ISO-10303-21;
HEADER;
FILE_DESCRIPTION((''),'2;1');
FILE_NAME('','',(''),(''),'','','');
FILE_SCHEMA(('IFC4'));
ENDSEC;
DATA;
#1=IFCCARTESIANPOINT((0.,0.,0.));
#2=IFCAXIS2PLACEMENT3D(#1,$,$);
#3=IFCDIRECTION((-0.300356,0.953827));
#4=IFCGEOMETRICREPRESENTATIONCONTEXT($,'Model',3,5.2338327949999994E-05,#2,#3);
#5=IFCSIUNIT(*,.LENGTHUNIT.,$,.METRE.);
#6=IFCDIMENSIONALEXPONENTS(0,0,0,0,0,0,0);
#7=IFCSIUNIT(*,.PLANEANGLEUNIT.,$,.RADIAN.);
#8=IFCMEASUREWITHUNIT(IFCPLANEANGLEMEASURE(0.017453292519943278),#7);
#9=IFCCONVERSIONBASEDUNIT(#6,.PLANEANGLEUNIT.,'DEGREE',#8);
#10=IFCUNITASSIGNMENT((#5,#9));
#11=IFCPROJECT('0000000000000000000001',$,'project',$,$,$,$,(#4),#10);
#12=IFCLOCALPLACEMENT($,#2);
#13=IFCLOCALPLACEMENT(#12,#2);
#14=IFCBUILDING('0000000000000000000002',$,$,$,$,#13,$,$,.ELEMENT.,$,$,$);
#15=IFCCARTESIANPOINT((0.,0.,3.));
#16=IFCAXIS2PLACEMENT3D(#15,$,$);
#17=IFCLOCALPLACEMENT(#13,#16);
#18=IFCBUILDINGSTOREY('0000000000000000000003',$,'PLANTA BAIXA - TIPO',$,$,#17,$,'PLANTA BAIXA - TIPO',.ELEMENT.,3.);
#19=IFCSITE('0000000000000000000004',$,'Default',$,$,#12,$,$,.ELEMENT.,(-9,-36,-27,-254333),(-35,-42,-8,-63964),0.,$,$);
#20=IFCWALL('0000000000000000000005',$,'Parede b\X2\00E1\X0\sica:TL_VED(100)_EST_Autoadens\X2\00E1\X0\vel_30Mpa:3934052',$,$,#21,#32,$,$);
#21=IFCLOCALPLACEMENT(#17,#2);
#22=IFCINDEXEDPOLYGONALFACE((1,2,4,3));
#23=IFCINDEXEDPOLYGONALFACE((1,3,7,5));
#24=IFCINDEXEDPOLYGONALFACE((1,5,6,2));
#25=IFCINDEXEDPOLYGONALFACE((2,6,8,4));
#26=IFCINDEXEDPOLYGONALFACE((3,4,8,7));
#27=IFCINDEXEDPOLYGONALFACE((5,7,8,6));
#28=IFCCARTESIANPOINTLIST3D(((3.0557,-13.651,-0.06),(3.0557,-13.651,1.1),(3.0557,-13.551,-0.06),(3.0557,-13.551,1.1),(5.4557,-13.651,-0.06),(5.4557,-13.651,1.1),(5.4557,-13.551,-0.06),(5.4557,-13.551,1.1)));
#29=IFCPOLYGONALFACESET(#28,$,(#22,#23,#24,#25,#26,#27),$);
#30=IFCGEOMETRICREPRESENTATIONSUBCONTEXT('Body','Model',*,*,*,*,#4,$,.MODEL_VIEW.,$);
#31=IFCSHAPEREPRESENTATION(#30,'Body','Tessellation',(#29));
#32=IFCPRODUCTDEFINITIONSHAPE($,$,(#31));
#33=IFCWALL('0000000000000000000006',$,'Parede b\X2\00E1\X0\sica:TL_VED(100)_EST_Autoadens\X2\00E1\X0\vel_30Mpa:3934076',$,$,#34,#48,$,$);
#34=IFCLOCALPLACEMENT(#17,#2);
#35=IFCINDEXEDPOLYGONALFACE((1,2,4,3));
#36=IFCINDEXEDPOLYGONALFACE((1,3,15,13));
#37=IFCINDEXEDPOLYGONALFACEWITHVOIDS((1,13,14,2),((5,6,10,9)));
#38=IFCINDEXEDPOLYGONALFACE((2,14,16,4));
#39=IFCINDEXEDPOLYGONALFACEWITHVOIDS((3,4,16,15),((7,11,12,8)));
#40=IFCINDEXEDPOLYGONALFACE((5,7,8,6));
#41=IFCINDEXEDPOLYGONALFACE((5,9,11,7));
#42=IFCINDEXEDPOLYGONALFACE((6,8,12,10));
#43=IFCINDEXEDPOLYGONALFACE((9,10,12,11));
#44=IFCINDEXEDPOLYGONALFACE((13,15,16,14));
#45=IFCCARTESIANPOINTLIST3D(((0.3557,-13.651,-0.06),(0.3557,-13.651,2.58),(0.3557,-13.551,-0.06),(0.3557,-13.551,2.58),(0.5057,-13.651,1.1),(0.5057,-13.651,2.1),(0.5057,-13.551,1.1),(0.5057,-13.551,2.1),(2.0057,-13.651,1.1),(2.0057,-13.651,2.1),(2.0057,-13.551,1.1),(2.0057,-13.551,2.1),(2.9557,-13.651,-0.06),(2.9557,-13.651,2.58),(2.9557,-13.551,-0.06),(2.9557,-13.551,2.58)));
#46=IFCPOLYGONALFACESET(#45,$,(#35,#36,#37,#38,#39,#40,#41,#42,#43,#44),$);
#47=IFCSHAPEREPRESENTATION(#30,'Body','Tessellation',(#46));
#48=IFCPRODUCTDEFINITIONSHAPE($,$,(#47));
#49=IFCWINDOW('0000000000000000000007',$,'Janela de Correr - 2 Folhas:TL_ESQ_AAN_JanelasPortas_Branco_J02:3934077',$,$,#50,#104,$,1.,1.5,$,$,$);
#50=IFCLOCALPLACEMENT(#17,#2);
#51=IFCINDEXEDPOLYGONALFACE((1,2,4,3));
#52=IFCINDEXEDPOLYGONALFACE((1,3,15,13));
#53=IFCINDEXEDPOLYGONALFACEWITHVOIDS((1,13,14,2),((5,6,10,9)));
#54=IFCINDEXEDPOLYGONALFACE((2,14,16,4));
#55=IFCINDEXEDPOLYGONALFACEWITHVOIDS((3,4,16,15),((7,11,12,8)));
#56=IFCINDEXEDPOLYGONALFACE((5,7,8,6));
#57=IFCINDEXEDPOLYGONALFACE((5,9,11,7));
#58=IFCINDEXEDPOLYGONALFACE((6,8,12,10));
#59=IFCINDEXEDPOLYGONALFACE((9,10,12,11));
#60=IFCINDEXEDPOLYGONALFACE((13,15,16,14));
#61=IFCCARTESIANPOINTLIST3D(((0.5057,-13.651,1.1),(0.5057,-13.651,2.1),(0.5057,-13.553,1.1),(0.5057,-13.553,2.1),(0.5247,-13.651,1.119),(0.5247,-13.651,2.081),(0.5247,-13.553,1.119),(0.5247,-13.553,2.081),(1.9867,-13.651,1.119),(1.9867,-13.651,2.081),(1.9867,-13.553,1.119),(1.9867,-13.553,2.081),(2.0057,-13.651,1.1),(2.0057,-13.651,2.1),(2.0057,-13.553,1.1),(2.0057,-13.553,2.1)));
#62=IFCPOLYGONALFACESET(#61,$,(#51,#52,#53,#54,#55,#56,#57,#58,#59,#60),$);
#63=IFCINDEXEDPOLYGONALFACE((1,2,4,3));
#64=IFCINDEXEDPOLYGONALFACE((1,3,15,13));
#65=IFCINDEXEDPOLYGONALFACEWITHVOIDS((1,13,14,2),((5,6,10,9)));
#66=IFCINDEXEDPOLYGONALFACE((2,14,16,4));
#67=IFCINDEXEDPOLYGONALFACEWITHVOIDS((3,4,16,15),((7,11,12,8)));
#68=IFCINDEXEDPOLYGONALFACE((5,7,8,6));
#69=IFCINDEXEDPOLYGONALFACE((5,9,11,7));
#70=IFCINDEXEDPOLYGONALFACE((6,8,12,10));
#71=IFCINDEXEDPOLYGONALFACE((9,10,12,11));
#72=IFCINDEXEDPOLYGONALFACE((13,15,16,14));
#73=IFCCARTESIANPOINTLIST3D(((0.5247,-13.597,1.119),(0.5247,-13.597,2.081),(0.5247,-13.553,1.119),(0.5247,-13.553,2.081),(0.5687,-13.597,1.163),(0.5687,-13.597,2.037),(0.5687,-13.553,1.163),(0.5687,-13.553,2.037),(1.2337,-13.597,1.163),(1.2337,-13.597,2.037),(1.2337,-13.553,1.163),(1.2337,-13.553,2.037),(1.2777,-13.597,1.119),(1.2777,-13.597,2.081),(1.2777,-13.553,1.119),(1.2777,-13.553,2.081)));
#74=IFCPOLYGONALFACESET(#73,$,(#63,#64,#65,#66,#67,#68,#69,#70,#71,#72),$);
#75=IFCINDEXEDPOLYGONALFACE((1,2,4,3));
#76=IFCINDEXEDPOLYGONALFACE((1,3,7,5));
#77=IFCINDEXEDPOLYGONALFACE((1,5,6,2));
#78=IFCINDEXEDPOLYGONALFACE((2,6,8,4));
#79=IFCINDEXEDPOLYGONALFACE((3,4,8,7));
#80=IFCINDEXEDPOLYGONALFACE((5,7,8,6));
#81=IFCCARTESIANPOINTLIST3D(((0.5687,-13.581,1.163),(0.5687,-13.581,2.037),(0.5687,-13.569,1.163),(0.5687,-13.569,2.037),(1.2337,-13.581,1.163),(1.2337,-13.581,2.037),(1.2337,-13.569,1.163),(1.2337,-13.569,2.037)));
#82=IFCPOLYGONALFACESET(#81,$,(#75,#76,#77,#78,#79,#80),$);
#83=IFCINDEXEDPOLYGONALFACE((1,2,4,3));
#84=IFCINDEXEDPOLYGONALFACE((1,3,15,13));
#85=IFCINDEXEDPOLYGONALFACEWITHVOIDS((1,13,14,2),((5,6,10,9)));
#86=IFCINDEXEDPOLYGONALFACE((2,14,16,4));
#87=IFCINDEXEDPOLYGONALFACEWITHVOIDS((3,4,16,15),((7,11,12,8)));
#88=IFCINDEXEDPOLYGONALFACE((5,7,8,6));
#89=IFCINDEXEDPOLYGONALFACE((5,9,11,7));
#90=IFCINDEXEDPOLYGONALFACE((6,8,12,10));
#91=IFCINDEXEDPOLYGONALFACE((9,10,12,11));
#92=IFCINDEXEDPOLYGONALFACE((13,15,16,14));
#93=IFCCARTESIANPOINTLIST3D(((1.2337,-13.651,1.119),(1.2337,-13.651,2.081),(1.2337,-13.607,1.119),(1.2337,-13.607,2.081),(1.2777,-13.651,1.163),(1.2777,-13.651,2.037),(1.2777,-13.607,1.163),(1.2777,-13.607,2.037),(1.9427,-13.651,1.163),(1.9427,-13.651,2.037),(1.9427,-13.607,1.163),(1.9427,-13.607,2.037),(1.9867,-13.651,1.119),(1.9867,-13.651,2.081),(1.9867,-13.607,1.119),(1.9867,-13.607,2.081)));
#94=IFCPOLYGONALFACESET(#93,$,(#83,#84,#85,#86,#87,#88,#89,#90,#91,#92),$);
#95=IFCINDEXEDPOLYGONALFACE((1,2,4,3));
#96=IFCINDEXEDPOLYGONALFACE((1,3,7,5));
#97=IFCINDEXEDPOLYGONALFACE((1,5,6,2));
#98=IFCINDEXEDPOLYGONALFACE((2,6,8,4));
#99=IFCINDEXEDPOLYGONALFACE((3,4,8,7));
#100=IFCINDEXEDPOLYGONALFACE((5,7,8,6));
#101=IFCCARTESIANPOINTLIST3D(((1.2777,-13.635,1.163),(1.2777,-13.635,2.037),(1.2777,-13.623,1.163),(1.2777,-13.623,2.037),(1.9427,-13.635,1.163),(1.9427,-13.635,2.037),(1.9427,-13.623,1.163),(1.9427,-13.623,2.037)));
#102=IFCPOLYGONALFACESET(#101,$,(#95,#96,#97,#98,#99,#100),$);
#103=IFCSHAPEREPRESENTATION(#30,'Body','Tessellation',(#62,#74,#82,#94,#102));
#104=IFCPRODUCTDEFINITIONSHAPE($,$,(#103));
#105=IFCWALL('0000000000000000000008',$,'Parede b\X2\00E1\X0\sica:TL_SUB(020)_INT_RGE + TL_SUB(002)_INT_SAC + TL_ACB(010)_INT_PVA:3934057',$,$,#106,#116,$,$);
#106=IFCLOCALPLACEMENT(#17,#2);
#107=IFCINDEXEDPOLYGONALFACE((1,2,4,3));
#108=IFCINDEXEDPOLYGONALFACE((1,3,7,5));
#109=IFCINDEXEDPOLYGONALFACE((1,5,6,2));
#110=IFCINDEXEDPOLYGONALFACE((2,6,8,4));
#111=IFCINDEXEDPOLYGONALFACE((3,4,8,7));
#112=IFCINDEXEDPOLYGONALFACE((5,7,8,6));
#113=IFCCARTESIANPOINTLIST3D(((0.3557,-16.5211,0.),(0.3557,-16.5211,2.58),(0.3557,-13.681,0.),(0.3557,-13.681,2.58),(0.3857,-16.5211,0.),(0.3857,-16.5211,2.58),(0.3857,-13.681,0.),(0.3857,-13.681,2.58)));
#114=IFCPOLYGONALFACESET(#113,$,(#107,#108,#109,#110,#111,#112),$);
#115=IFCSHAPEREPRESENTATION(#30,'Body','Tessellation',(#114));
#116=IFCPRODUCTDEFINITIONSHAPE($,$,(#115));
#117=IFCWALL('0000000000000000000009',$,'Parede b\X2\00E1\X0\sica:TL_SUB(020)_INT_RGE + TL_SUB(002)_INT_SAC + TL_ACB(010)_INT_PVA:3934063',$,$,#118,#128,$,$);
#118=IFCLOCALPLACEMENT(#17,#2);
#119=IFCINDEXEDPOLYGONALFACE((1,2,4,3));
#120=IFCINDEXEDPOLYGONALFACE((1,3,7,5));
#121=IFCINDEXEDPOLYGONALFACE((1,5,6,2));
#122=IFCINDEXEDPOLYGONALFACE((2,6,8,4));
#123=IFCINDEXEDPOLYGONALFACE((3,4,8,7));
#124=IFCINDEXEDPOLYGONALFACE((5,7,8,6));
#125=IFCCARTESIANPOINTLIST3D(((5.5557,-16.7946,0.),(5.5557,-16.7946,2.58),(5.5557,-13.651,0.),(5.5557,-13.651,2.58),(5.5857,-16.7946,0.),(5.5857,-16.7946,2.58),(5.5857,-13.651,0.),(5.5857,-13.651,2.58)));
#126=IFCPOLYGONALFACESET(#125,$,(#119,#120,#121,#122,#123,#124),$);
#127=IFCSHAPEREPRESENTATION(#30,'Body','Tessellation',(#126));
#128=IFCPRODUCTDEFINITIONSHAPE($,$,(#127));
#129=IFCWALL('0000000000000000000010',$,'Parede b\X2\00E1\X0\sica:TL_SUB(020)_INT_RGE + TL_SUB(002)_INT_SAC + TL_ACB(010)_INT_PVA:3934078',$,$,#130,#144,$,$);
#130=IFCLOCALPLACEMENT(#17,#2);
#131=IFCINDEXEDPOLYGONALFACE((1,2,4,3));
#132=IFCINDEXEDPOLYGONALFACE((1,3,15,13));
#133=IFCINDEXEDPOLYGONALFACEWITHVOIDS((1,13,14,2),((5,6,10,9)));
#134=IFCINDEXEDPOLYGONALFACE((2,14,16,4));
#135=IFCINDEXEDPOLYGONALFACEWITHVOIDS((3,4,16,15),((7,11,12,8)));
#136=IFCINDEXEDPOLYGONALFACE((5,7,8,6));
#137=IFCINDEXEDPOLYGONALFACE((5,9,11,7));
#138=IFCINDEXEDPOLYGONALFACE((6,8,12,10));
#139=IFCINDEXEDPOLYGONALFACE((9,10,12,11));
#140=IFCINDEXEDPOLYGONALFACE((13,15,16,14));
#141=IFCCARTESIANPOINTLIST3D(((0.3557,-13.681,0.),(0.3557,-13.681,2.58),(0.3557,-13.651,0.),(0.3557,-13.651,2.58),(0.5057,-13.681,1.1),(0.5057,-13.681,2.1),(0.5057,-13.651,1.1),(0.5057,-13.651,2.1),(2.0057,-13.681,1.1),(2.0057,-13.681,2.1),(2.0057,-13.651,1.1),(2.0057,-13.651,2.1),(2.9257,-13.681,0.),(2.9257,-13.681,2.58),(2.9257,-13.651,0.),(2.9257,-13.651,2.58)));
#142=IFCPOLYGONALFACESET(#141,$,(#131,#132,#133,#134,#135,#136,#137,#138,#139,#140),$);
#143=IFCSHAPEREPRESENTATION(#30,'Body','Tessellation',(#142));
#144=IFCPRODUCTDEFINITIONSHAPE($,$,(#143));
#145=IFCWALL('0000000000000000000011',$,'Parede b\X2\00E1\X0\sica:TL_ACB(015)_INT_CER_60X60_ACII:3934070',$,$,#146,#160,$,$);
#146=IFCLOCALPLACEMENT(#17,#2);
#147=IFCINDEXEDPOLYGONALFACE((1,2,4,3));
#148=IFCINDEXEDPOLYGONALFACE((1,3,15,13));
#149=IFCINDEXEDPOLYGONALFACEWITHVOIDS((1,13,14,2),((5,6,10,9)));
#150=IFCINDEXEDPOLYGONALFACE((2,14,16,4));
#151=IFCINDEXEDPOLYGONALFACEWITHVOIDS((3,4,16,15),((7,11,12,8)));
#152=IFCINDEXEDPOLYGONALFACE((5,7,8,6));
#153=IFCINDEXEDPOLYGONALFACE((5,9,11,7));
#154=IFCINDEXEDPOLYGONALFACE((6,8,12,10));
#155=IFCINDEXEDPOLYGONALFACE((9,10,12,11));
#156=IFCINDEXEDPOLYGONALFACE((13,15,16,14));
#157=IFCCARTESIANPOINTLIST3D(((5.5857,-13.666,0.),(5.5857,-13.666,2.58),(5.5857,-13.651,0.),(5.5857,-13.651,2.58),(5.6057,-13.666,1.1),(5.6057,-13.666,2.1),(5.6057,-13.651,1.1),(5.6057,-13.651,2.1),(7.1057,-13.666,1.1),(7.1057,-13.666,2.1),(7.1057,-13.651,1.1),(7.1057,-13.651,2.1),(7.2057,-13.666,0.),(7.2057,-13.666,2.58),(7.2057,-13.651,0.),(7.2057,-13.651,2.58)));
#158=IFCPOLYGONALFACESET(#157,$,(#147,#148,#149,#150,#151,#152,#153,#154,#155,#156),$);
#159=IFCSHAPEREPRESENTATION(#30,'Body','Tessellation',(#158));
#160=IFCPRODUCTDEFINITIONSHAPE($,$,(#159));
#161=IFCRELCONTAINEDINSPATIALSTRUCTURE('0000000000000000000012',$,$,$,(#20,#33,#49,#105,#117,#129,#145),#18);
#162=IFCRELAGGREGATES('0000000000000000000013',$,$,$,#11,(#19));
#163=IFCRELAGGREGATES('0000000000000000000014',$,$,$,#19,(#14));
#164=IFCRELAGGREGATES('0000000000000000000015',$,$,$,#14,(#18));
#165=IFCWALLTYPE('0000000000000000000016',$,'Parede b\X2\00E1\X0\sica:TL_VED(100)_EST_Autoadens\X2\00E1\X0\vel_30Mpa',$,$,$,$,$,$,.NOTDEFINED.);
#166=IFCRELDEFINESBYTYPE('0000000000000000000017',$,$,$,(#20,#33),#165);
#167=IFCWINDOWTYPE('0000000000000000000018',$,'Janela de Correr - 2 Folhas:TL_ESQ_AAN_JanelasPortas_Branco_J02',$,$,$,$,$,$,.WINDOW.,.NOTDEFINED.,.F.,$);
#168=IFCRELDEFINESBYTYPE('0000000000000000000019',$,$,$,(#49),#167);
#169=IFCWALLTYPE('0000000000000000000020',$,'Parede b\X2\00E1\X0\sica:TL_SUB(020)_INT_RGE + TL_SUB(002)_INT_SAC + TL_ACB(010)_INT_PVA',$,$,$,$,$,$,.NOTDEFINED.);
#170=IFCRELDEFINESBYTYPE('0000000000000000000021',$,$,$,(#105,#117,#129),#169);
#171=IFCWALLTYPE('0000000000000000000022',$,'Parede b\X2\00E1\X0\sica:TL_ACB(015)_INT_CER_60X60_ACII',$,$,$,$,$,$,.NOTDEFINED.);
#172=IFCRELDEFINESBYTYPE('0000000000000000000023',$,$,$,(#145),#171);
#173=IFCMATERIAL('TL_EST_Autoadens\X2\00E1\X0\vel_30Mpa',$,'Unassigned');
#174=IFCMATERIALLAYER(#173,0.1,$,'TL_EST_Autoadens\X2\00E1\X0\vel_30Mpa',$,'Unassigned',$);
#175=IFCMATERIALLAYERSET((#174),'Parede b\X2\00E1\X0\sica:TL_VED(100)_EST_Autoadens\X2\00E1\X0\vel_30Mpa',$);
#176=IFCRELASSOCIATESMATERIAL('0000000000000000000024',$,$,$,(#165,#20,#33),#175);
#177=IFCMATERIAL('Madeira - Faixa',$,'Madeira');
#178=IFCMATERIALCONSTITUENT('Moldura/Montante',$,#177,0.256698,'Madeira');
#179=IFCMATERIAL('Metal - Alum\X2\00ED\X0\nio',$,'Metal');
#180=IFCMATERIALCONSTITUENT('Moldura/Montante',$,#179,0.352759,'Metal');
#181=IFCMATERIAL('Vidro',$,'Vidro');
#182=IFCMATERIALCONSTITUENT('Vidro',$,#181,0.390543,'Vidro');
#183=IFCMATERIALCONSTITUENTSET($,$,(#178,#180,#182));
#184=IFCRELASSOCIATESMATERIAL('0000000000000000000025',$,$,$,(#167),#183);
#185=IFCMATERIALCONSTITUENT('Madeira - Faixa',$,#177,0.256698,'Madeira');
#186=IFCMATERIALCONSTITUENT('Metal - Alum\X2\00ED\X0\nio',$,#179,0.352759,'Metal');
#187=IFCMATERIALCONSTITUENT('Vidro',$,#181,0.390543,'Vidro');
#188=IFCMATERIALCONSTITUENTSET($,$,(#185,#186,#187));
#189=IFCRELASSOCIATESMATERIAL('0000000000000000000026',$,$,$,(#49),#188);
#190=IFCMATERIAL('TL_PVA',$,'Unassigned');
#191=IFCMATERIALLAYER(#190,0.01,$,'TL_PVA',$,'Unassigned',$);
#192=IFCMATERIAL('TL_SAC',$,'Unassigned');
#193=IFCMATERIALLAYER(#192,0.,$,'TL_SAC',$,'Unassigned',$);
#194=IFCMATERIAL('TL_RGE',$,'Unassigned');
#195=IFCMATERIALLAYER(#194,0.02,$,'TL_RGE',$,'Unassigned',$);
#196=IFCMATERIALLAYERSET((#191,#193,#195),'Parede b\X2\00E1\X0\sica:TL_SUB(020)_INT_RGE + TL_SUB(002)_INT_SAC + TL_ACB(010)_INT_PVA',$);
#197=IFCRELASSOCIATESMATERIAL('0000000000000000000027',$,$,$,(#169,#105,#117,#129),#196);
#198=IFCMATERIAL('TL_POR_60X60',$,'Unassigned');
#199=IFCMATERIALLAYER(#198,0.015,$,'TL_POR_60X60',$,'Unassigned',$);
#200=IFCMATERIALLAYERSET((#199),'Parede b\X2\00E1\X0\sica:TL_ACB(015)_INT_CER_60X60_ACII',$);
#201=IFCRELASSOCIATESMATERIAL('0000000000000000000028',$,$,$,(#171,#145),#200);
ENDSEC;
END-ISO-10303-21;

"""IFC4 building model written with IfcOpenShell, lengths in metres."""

from ifc_helpers import new_model, entity, si_unit, converted_unit, direction, frame, frame_2d, origin, origin_2d_with_axis, place, context, subcontext, project, spatial, polyline, rectangle, outline, extrude, source, transform, mapped, material, layer, layer_set, layer_usage, constituent, constituent_set, type_object, type_shapes, element, fill, save


model = new_model("IFC4")

# Units and contexts
model_context = context("Model", 3, precision=5.2338327949999994e-05, world=origin(), true_north=direction((-0.300356, 0.953827)))
body_context = subcontext(model_context, "Body", "Model", "MODEL_VIEW")
ifc_project = project(units=[si_unit("LENGTHUNIT", "METRE"), converted_unit("PLANEANGLEUNIT", "DEGREE", entity("IfcPlaneAngleMeasure", 0.017453292519943278), si_unit("PLANEANGLEUNIT", "RADIAN"), dimensions=[0, 0, 0, 0, 0, 0, 0])], contexts=[model_context])

# Site, building, storey
site_placement = place(None, origin())
site = spatial("IfcSite", under=ifc_project, at=site_placement, Name="Default", CompositionType="ELEMENT", RefLatitude=(-9, -36, -27, -254333), RefLongitude=(-35, -42, -8, -63964), RefElevation=0.0)
building_placement = place(site_placement, origin())
building = spatial("IfcBuilding", under=site, at=building_placement, CompositionType="ELEMENT")
storey_placement = place(building_placement, frame((0.0, 0.0, 3.0)))
storey = spatial("IfcBuildingStorey", under=building, at=storey_placement, Name="PLANTA BAIXA - TIPO", LongName="PLANTA BAIXA - TIPO", CompositionType="ELEMENT", Elevation=3.0)

# Wall
ifc_material_1 = material(Name="TL_EST_Autoadensável_30Mpa", Category="Unassigned")
ifc_layer_1 = layer(ifc_material_1, 0.1, Name="TL_EST_Autoadensável_30Mpa", Category="Unassigned")
ifc_layer_set_1 = layer_set([ifc_layer_1], Name="Parede básica:TL_VED(100)_EST_Autoadensável_30Mpa")
ifc_layer_usage_1 = layer_usage(ifc_layer_set_1, "AXIS2", "NEGATIVE", 0.05)
wall_type_1 = type_object("IfcWallType", Name="Parede básica:TL_VED(100)_EST_Autoadensável_30Mpa", PredefinedType="NOTDEFINED", material=ifc_layer_set_1)
wall_1_placement = place(storey_placement, frame((3.0557, -13.601, -0.06)))
element("IfcWall", 1, at=wall_1_placement, inside=storey, type_object=wall_type_1, material=ifc_layer_usage_1, Name="Parede básica:TL_VED(100)_EST_Autoadensável_30Mpa:3934052", context=body_context, shape_type="SweptSolid", body=[
    extrude(rectangle(XDim=2.4, YDim=0.1, at=frame_2d((1.2, 0.0), x_axis=(-1.0, 0.0))), origin(), (0.0, 0.0, 1.0), 1.16),
])

# Wall, opening, window
ifc_layer_usage_2 = layer_usage(ifc_layer_set_1, "AXIS2", "NEGATIVE", 0.05)
wall_2_placement = place(storey_placement, frame((0.3557, -13.601, -0.06)))
wall_2 = element("IfcWall", 2, at=wall_2_placement, inside=storey, type_object=wall_type_1, material=ifc_layer_usage_2, Name="Parede básica:TL_VED(100)_EST_Autoadensável_30Mpa:3934076", context=body_context, shape_type="SweptSolid", body=[
    extrude(rectangle(XDim=2.6, YDim=0.1, at=frame_2d((1.3, 0.0), x_axis=(-1.0, 0.0))), origin(), (0.0, 0.0, 1.0), 2.64),
])
opening_1_placement = place(wall_2_placement, frame((0.15, -0.05, 1.16)))
opening_1 = element("IfcOpeningElement", 3, at=opening_1_placement, cuts=wall_2, PredefinedType="OPENING", context=body_context, shape_type="SweptSolid", body=[
    extrude(rectangle(XDim=1.0, YDim=1.5, at=frame_2d((0.5, 0.75), x_axis=(-1.0, 0.0))), frame((0.0, 0.0, 0.0), z_axis=(0.0, 1.0, 0.0), x_axis=(0.0, 0.0, 1.0)), (0.0, 0.0, 1.0), 0.1),
])
ifc_material_2 = material(Name="Madeira - Faixa", Category="Madeira")
ifc_constituent_1 = constituent(ifc_material_2, Name="Madeira - Faixa", Category="Madeira", fraction=0.256698)
ifc_material_3 = material(Name="Metal - Alumínio", Category="Metal")
ifc_constituent_2 = constituent(ifc_material_3, Name="Metal - Alumínio", Category="Metal", fraction=0.352759)
ifc_material_4 = material(Name="Vidro", Category="Vidro")
ifc_constituent_3 = constituent(ifc_material_4, Name="Vidro", Category="Vidro", fraction=0.390543)
ifc_constituent_set_1 = constituent_set(constituents=[ifc_constituent_1, ifc_constituent_2, ifc_constituent_3])
ifc_constituent_4 = constituent(ifc_material_2, Name="Moldura/Montante", Category="Madeira", fraction=0.256698)
ifc_constituent_5 = constituent(ifc_material_3, Name="Moldura/Montante", Category="Metal", fraction=0.352759)
ifc_constituent_6 = constituent(ifc_material_4, Name="Vidro", Category="Vidro", fraction=0.390543)
ifc_constituent_set_2 = constituent_set(constituents=[ifc_constituent_4, ifc_constituent_5, ifc_constituent_6])
window_type = type_object("IfcWindowType", Name="Janela de Correr - 2 Folhas:TL_ESQ_AAN_JanelasPortas_Branco_J02", ParameterTakesPrecedence=False, PartitioningType="NOTDEFINED", PredefinedType="WINDOW", material=ifc_constituent_set_2)
shared_shape_1 = source(origin(), body_context, "Body", "SweptSolid", [
    extrude(outline(polyline([(-0.75, -0.5), (0.75, -0.5), (0.75, 0.5), (-0.75, 0.5), (-0.75, -0.5)]), holes=[polyline([(-0.731, -0.481), (-0.731, 0.481), (0.731, 0.481), (0.731, -0.481), (-0.731, -0.481)])]), frame((0.75, 0.124, 0.5), z_axis=(0.0, -1.0, 0.0), x_axis=(-1.0, 0.0, 0.0)), (0.0, 0.0, 1.0), 0.098),
    extrude(outline(polyline([(-0.3765, -0.481), (0.3765, -0.481), (0.3765, 0.481), (-0.3765, 0.481), (-0.3765, -0.481)]), holes=[polyline([(-0.3325, -0.437), (-0.3325, 0.437), (0.3325, 0.437), (0.3325, -0.437), (-0.3325, -0.437)])]), frame((0.3955, 0.124, 0.5), z_axis=(0.0, -1.0, 0.0), x_axis=(-1.0, 0.0, 0.0)), (0.0, 0.0, 1.0), 0.044),
    extrude(rectangle(XDim=0.665, YDim=0.012, at=origin_2d_with_axis()), frame((0.3955, 0.102, 0.063), z_axis=(0.0, 0.0, 1.0), x_axis=(-1.0, 0.0, 0.0)), (0.0, 0.0, 1.0), 0.874),
    extrude(outline(polyline([(-0.481, -0.3765), (0.481, -0.3765), (0.481, 0.3765), (-0.481, 0.3765), (-0.481, -0.3765)]), holes=[polyline([(-0.437, -0.3325), (-0.437, 0.3325), (0.437, 0.3325), (0.437, -0.3325), (-0.437, -0.3325)])]), frame((1.1045, 0.07, 0.5), z_axis=(0.0, -1.0, 0.0), x_axis=(0.0, 0.0, -1.0)), (0.0, 0.0, 1.0), 0.044),
    extrude(rectangle(XDim=0.665, YDim=0.012, at=origin_2d_with_axis()), frame((1.1045, 0.048, 0.063), z_axis=(0.0, 0.0, 1.0), x_axis=(-1.0, 0.0, 0.0)), (0.0, 0.0, 1.0), 0.874),
])
type_shapes(window_type, [shared_shape_1])
window_placement = place(opening_1_placement, frame((0.0, -0.026, 0.0)))
window = element("IfcWindow", 4, at=window_placement, inside=storey, type_object=window_type, material=ifc_constituent_set_1, Name="Janela de Correr - 2 Folhas:TL_ESQ_AAN_JanelasPortas_Branco_J02:3934077", OverallHeight=1.0, OverallWidth=1.5, context=body_context, shape_type="MappedRepresentation", body=[
    mapped(shared_shape_1, transform((0.0, 0.0, 0.0), scale=1.0)),
])
fill(opening_1, window)

# Walls
ifc_material_5 = material(Name="TL_PVA", Category="Unassigned")
ifc_layer_2 = layer(ifc_material_5, 0.01, Name="TL_PVA", Category="Unassigned")
ifc_material_6 = material(Name="TL_SAC", Category="Unassigned")
ifc_layer_3 = layer(ifc_material_6, 0.0, Name="TL_SAC", Category="Unassigned")
ifc_material_7 = material(Name="TL_RGE", Category="Unassigned")
ifc_layer_4 = layer(ifc_material_7, 0.02, Name="TL_RGE", Category="Unassigned")
ifc_layer_set_2 = layer_set([ifc_layer_2, ifc_layer_3, ifc_layer_4], Name="Parede básica:TL_SUB(020)_INT_RGE + TL_SUB(002)_INT_SAC + TL_ACB(010)_INT_PVA")
ifc_layer_usage_3 = layer_usage(ifc_layer_set_2, "AXIS2", "NEGATIVE", 0.015)
wall_type_2 = type_object("IfcWallType", Name="Parede básica:TL_SUB(020)_INT_RGE + TL_SUB(002)_INT_SAC + TL_ACB(010)_INT_PVA", PredefinedType="NOTDEFINED", material=ifc_layer_set_2)
wall_3_placement = place(storey_placement, frame((0.3707, -13.681, 0.0), z_axis=(0.0, 0.0, 1.0), x_axis=(0.0, -1.0, 0.0)))
element("IfcWall", 5, at=wall_3_placement, inside=storey, type_object=wall_type_2, material=ifc_layer_usage_3, Name="Parede básica:TL_SUB(020)_INT_RGE + TL_SUB(002)_INT_SAC + TL_ACB(010)_INT_PVA:3934057", context=body_context, shape_type="SweptSolid", body=[
    extrude(rectangle(XDim=2.8401, YDim=0.03, at=frame_2d((1.4201, 0.0), x_axis=(-1.0, 0.0))), origin(), (0.0, 0.0, 1.0), 2.58),
])
ifc_layer_usage_4 = layer_usage(ifc_layer_set_2, "AXIS2", "NEGATIVE", 0.015)
wall_4_placement = place(storey_placement, frame((5.5707, -13.651, 0.0), z_axis=(0.0, 0.0, 1.0), x_axis=(0.0, -1.0, 0.0)))
element("IfcWall", 6, at=wall_4_placement, inside=storey, type_object=wall_type_2, material=ifc_layer_usage_4, Name="Parede básica:TL_SUB(020)_INT_RGE + TL_SUB(002)_INT_SAC + TL_ACB(010)_INT_PVA:3934063", context=body_context, shape_type="SweptSolid", body=[
    extrude(rectangle(XDim=3.1437, YDim=0.03, at=frame_2d((1.5718, 0.0), x_axis=(-1.0, 0.0))), origin(), (0.0, 0.0, 1.0), 2.58),
])

# Walls, openings
ifc_layer_usage_5 = layer_usage(ifc_layer_set_2, "AXIS2", "NEGATIVE", 0.015)
wall_5_placement = place(storey_placement, frame((2.9257, -13.666, 0.0), z_axis=(0.0, 0.0, 1.0), x_axis=(-1.0, 0.0, 0.0)))
wall_5 = element("IfcWall", 7, at=wall_5_placement, inside=storey, type_object=wall_type_2, material=ifc_layer_usage_5, Name="Parede básica:TL_SUB(020)_INT_RGE + TL_SUB(002)_INT_SAC + TL_ACB(010)_INT_PVA:3934078", context=body_context, shape_type="SweptSolid", body=[
    extrude(rectangle(XDim=2.57, YDim=0.03, at=frame_2d((1.285, 0.0), x_axis=(-1.0, 0.0))), origin(), (0.0, 0.0, 1.0), 2.58),
])
opening_2_placement = place(wall_5_placement, frame((2.9257, -13.666, 1.1)))
element("IfcOpeningElement", 8, at=opening_2_placement, cuts=wall_5, PredefinedType="OPENING", context=body_context, shape_type="SweptSolid", body=[
    extrude(rectangle(XDim=1.0, YDim=1.5, at=frame_2d((0.0, 0.0), x_axis=(0.0, 1.0))), frame((-1.2557, 12.127, 0.5), z_axis=(0.0, 1.0, 0.0), x_axis=(1.0, 0.0, 0.0)), (0.0, 0.0, 1.0), 3.048),
])
ifc_material_8 = material(Name="TL_POR_60X60", Category="Unassigned")
ifc_layer_5 = layer(ifc_material_8, 0.015, Name="TL_POR_60X60", Category="Unassigned")
ifc_layer_set_3 = layer_set([ifc_layer_5], Name="Parede básica:TL_ACB(015)_INT_CER_60X60_ACII")
ifc_layer_usage_6 = layer_usage(ifc_layer_set_3, "AXIS2", "NEGATIVE", 0.0075)
wall_type_3 = type_object("IfcWallType", Name="Parede básica:TL_ACB(015)_INT_CER_60X60_ACII", PredefinedType="NOTDEFINED", material=ifc_layer_set_3)
wall_6_placement = place(storey_placement, frame((7.2057, -13.6585, 0.0), z_axis=(0.0, 0.0, 1.0), x_axis=(-1.0, 0.0, 0.0)))
wall_6 = element("IfcWall", 9, at=wall_6_placement, inside=storey, type_object=wall_type_3, material=ifc_layer_usage_6, Name="Parede básica:TL_ACB(015)_INT_CER_60X60_ACII:3934070", context=body_context, shape_type="SweptSolid", body=[
    extrude(rectangle(XDim=1.62, YDim=0.015, at=frame_2d((0.81, 0.0), x_axis=(-1.0, 0.0))), origin(), (0.0, 0.0, 1.0), 2.58),
])
opening_3_placement = place(wall_6_placement, frame((7.2057, -13.6585, 1.1)))
element("IfcOpeningElement", 10, at=opening_3_placement, cuts=wall_6, PredefinedType="OPENING", context=body_context, shape_type="SweptSolid", body=[
    extrude(rectangle(XDim=1.0, YDim=1.5, at=frame_2d((0.0, 0.0), x_axis=(0.0, 1.0))), frame((-6.3557, 12.127, 0.5), z_axis=(0.0, 1.0, 0.0), x_axis=(1.0, 0.0, 0.0)), (0.0, 0.0, 1.0), 3.048),
])

save(model, "model.ifc")
